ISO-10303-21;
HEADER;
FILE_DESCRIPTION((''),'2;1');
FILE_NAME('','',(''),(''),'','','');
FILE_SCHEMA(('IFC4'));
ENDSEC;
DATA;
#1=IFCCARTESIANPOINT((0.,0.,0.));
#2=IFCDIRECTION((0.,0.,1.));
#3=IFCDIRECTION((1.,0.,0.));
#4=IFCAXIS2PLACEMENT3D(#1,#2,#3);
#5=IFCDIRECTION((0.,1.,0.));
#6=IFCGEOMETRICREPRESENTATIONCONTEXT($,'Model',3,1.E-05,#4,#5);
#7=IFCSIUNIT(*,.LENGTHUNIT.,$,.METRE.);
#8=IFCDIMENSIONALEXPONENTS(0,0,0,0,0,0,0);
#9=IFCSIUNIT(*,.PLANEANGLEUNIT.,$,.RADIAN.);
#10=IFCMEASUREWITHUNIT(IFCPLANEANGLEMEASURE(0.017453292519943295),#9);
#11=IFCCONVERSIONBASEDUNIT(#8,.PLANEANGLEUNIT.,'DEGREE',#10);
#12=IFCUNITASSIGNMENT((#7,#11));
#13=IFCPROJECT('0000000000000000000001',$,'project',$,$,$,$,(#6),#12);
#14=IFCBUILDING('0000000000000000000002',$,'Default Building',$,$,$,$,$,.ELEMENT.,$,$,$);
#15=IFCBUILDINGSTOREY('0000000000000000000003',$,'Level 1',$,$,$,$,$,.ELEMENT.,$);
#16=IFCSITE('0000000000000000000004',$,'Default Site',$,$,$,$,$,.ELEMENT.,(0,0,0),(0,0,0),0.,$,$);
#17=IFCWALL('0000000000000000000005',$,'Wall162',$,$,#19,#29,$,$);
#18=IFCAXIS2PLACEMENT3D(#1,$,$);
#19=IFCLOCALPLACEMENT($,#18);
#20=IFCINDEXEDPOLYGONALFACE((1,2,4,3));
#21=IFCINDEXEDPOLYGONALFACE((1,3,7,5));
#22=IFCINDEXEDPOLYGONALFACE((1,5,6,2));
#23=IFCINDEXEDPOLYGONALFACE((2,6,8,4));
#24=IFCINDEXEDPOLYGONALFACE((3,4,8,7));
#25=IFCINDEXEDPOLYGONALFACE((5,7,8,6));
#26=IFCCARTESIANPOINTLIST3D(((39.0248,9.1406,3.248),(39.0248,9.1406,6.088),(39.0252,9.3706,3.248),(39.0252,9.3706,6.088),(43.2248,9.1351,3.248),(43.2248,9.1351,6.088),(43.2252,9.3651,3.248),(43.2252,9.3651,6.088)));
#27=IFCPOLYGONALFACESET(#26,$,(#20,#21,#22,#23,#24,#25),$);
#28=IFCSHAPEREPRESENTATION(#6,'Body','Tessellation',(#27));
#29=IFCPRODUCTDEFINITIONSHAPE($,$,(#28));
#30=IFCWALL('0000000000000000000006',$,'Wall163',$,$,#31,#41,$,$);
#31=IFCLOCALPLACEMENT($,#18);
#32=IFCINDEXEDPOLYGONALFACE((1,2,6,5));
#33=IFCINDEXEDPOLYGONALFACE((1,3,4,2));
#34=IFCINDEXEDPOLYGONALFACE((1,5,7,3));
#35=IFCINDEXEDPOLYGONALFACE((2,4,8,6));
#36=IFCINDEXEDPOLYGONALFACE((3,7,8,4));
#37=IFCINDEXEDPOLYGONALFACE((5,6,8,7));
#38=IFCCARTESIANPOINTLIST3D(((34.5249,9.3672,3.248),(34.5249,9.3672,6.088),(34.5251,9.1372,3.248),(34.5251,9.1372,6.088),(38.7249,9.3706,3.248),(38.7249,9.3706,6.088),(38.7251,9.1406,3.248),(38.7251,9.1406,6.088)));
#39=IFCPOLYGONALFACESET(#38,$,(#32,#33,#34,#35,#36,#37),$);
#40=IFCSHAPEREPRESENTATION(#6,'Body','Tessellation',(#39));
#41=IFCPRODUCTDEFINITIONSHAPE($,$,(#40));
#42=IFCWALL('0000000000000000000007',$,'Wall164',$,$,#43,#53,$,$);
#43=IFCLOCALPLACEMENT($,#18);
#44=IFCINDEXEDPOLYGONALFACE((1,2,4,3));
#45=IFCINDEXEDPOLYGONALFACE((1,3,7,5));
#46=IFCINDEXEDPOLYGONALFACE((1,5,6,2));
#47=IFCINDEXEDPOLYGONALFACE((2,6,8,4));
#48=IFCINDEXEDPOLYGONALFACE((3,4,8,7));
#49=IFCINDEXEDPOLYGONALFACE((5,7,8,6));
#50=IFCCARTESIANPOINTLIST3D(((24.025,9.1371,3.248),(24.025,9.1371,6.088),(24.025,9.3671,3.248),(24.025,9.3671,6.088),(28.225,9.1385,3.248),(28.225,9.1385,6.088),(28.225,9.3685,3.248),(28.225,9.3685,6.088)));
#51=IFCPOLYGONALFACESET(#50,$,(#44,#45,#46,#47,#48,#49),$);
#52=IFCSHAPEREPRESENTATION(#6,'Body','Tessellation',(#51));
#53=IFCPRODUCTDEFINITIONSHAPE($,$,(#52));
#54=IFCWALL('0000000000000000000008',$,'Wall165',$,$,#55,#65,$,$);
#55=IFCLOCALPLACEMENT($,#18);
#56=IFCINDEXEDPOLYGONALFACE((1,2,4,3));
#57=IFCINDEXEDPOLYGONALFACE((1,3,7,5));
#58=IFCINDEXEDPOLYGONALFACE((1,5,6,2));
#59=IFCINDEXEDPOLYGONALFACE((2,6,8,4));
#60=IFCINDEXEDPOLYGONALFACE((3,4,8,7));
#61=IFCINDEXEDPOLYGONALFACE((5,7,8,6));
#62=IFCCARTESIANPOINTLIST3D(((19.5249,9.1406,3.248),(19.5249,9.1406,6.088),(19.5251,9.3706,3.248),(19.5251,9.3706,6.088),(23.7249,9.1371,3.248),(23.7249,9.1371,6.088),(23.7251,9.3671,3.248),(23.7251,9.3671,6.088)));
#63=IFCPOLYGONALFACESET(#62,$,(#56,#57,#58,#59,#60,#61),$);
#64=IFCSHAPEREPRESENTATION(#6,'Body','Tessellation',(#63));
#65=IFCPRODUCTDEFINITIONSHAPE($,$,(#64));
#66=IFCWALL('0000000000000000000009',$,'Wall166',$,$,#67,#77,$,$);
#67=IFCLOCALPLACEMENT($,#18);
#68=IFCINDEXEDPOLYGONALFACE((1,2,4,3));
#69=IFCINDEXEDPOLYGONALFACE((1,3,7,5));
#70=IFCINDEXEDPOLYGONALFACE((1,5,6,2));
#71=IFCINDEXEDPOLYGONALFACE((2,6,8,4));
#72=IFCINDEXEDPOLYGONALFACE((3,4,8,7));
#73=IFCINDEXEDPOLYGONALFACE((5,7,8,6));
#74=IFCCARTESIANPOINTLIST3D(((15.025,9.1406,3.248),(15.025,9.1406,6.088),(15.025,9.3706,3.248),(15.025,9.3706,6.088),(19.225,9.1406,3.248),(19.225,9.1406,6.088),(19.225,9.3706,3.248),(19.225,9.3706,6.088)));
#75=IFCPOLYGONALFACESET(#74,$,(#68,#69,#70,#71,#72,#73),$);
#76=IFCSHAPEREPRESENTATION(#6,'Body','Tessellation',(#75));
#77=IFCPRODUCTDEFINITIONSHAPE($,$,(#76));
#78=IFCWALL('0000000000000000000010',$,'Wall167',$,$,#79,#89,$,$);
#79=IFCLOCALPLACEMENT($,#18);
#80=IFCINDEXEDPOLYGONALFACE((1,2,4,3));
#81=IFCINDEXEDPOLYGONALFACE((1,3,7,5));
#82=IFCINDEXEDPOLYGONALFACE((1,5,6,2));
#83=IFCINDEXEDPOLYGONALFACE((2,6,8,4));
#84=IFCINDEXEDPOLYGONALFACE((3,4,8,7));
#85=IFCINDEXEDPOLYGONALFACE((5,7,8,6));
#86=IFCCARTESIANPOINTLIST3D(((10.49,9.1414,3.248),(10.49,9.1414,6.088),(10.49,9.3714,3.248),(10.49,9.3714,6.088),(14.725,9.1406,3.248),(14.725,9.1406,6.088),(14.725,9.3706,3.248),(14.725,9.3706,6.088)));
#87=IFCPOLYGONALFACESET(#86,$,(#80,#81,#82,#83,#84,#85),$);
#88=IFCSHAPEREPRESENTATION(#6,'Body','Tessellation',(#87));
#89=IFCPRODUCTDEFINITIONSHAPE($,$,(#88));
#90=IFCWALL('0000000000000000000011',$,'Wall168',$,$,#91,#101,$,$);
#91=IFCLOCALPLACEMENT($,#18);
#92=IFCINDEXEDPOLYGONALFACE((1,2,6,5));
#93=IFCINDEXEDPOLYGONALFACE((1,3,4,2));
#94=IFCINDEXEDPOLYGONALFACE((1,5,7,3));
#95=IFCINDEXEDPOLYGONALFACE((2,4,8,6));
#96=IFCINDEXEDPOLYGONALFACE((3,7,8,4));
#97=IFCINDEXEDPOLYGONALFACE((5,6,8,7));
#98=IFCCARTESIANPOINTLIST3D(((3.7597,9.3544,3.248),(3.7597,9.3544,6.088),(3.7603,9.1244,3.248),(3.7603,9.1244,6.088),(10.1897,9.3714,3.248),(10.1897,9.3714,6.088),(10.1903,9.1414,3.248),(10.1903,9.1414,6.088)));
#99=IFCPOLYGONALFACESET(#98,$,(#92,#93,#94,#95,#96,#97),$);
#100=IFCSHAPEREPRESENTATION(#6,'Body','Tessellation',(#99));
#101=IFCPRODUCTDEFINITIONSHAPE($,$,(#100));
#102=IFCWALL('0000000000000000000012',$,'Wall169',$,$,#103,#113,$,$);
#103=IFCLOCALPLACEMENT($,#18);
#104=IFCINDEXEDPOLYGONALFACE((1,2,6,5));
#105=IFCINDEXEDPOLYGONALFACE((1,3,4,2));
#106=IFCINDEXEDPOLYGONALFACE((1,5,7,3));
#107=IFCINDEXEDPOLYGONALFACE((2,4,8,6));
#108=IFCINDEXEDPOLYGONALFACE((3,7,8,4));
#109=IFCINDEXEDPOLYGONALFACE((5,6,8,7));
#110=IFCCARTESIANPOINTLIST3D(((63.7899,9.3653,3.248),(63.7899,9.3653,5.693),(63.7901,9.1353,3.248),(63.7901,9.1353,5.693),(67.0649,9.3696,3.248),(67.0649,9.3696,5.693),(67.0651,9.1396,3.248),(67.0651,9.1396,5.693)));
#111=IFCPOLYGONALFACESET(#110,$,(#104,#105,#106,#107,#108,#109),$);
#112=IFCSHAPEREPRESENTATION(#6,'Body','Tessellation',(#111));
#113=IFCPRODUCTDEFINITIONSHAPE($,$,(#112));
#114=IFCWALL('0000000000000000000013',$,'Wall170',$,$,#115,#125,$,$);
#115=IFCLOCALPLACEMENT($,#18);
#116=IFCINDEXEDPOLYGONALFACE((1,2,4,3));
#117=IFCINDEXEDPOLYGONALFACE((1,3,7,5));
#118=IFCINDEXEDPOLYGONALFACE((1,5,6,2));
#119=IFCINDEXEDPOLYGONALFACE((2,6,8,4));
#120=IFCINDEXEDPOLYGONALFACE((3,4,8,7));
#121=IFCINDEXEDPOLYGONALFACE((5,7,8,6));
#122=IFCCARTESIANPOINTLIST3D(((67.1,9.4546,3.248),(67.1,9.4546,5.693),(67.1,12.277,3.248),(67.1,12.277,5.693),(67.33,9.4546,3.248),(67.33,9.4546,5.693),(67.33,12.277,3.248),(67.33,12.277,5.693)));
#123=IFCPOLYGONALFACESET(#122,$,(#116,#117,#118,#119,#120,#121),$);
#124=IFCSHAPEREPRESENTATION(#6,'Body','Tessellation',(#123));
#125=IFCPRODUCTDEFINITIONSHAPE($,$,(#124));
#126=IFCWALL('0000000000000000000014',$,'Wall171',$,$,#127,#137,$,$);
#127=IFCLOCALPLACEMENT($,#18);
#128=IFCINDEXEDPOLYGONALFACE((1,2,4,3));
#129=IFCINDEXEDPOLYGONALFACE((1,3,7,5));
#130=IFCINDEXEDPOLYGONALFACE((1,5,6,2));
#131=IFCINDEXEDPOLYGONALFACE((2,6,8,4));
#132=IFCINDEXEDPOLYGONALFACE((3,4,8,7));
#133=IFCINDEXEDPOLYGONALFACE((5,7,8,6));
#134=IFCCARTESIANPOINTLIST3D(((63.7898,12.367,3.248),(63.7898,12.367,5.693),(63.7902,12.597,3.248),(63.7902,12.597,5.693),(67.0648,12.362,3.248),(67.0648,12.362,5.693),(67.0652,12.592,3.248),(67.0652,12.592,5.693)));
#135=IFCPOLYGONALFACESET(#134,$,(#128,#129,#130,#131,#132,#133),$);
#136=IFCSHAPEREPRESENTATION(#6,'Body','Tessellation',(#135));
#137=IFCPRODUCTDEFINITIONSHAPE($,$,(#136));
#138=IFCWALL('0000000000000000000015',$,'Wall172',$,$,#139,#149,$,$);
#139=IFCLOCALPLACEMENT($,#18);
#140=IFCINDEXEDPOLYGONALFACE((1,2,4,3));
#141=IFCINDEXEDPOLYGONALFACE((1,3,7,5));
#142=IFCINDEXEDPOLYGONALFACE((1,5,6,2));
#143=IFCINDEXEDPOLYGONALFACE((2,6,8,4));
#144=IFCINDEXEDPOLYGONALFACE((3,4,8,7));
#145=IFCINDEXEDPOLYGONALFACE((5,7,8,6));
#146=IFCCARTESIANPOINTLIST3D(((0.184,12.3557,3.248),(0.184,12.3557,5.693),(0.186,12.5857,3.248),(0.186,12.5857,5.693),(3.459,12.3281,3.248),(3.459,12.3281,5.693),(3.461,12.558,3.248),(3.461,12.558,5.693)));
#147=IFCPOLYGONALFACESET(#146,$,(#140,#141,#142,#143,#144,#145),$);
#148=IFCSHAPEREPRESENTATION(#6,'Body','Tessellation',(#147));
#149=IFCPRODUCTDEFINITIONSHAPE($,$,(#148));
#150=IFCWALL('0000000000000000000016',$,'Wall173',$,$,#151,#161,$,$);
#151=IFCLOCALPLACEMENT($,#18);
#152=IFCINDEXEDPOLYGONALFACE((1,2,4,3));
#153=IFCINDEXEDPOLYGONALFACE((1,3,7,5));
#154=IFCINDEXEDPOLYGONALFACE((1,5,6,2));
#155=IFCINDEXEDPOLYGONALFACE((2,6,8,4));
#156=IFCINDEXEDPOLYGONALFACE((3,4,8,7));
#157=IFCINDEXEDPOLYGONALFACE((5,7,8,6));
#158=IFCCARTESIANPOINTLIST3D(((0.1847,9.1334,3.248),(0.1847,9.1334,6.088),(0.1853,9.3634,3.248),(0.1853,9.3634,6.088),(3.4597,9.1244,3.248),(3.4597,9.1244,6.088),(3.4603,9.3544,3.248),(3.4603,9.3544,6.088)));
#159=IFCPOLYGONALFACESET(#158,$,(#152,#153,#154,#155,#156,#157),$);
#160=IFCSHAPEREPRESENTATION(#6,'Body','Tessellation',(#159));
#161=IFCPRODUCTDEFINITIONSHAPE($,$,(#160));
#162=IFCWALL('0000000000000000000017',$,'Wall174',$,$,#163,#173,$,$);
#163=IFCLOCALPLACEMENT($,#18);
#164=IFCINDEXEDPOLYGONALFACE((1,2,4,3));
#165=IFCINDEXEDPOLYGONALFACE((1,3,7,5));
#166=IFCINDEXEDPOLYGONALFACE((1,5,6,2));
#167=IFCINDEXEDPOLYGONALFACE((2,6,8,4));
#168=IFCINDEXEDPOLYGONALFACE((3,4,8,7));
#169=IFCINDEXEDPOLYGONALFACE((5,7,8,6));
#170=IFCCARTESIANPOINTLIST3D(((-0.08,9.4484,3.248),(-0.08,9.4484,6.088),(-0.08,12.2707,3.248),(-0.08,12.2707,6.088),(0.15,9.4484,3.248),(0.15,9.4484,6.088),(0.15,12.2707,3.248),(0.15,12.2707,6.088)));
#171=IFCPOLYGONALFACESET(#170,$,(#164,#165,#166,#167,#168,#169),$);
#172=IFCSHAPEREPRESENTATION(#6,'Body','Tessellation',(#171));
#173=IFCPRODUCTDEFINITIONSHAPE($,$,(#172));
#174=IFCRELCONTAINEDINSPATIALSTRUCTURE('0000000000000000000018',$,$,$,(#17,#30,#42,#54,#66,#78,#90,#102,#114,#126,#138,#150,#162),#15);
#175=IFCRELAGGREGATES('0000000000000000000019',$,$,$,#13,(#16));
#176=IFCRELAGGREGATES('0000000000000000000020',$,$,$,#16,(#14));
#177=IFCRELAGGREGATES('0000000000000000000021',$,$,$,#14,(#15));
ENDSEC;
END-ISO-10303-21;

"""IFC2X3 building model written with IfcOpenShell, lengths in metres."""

from ifc_helpers import new_model, entity, si_unit, converted_unit, direction, frame, frame_2d, origin_with_axes, place, context, project, spatial, rectangle, extrude, element, save


model = new_model("IFC2X3")

# Units and contexts
model_context = context("Model", 3, precision=1e-05, world=origin_with_axes(), true_north=direction((0.0, 1.0, 0.0)))
ifc_project = project(units=[si_unit("LENGTHUNIT", "METRE"), converted_unit("PLANEANGLEUNIT", "DEGREE", entity("IfcPlaneAngleMeasure", 0.017453292519943295), si_unit("PLANEANGLEUNIT", "RADIAN"), dimensions=[0, 0, 0, 0, 0, 0, 0])], contexts=[model_context])

# Site, building, storey
site = spatial("IfcSite", under=ifc_project, Name="Default Site", CompositionType="ELEMENT", RefLatitude=(0, 0, 0), RefLongitude=(0, 0, 0), RefElevation=0.0)
building = spatial("IfcBuilding", under=site, Name="Default Building", CompositionType="ELEMENT")
storey = spatial("IfcBuildingStorey", under=building, Name="Level 1", CompositionType="ELEMENT")

# Walls
placement = place(None, origin_with_axes())
element("IfcWall", 1, at=placement, inside=storey, Name="Wall162", context=model_context, shape_type="SweptSolid", body=[
    extrude(rectangle(XDim=4.2, YDim=0.23, at=frame_2d((0.0, 0.0), x_axis=(-0.999999, 0.001314, 0.0))), frame((41.125, 9.2528, 3.248), z_axis=(0.0, 0.0, 1.0), x_axis=(1.0, 0.0, 0.0)), (0.0, 0.0, 1.0), 2.84),
])
element("IfcWall", 2, at=placement, inside=storey, Name="Wall163", context=model_context, shape_type="SweptSolid", body=[
    extrude(rectangle(XDim=4.2, YDim=0.23, at=frame_2d((0.0, 0.0), x_axis=(1.0, 0.000801, 0.0))), frame((36.625, 9.2539, 3.248), z_axis=(0.0, 0.0, 1.0), x_axis=(1.0, 0.0, 0.0)), (0.0, 0.0, 1.0), 2.84),
])
element("IfcWall", 3, at=placement, inside=storey, Name="Wall164", context=model_context, shape_type="SweptSolid", body=[
    extrude(rectangle(XDim=4.2, YDim=0.23, at=frame_2d((0.0, 0.0), x_axis=(-1.0, -0.000329, 0.0))), frame((26.125, 9.2528, 3.248), z_axis=(0.0, 0.0, 1.0), x_axis=(1.0, 0.0, 0.0)), (0.0, 0.0, 1.0), 2.84),
])
element("IfcWall", 4, at=placement, inside=storey, Name="Wall165", context=model_context, shape_type="SweptSolid", body=[
    extrude(rectangle(XDim=4.2, YDim=0.23, at=frame_2d((0.0, 0.0), x_axis=(-1.0, 0.000835, 0.0))), frame((21.625, 9.2539, 3.248), z_axis=(0.0, 0.0, 1.0), x_axis=(1.0, 0.0, 0.0)), (0.0, 0.0, 1.0), 2.84),
])
element("IfcWall", 5, at=placement, inside=storey, Name="Wall166", context=model_context, shape_type="SweptSolid", body=[
    extrude(rectangle(XDim=4.2, YDim=0.23, at=frame_2d((0.0, 0.0), x_axis=(-1.0, -0.000014, 0.0))), frame((17.125, 9.2556, 3.248), z_axis=(0.0, 0.0, 1.0), x_axis=(1.0, 0.0, 0.0)), (0.0, 0.0, 1.0), 2.84),
])
element("IfcWall", 6, at=placement, inside=storey, Name="Wall167", context=model_context, shape_type="SweptSolid", body=[
    extrude(rectangle(XDim=4.235, YDim=0.23, at=frame_2d((0.0, 0.0), x_axis=(1.0, -0.000195, 0.0))), frame((12.6075, 9.256, 3.248), z_axis=(0.0, 0.0, 1.0), x_axis=(1.0, 0.0, 0.0)), (0.0, 0.0, 1.0), 2.84),
])
element("IfcWall", 7, at=placement, inside=storey, Name="Wall168", context=model_context, shape_type="SweptSolid", body=[
    extrude(rectangle(XDim=6.43, YDim=0.23, at=frame_2d((0.0, 0.0), x_axis=(-0.999997, -0.002639, 0.0))), frame((6.975, 9.2479, 3.248), z_axis=(0.0, 0.0, 1.0), x_axis=(1.0, 0.0, 0.0)), (0.0, 0.0, 1.0), 2.84),
])
element("IfcWall", 8, at=placement, inside=storey, Name="Wall169", context=model_context, shape_type="SweptSolid", body=[
    extrude(rectangle(XDim=3.275, YDim=0.23, at=frame_2d((0.0, 0.0), x_axis=(0.999999, 0.001297, 0.0))), frame((65.4275, 9.2525, 3.248), z_axis=(0.0, 0.0, 1.0), x_axis=(1.0, 0.0, 0.0)), (0.0, 0.0, 1.0), 2.445),
])
element("IfcWall", 9, at=placement, inside=storey, Name="Wall170", context=model_context, shape_type="SweptSolid", body=[
    extrude(rectangle(XDim=2.8224, YDim=0.23, at=frame_2d((0.0, 0.0), x_axis=(0.0, -1.0, 0.0))), frame((67.215, 10.8658, 3.248), z_axis=(0.0, 0.0, 1.0), x_axis=(1.0, 0.0, 0.0)), (0.0, 0.0, 1.0), 2.445),
])
element("IfcWall", 10, at=placement, inside=storey, Name="Wall171", context=model_context, shape_type="SweptSolid", body=[
    extrude(rectangle(XDim=3.275, YDim=0.23, at=frame_2d((0.0, 0.0), x_axis=(0.999999, -0.001506, 0.0))), frame((65.4275, 12.4795, 3.248), z_axis=(0.0, 0.0, 1.0), x_axis=(1.0, 0.0, 0.0)), (0.0, 0.0, 1.0), 2.445),
])
element("IfcWall", 11, at=placement, inside=storey, Name="Wall172", context=model_context, shape_type="SweptSolid", body=[
    extrude(rectangle(XDim=3.2751, YDim=0.23, at=frame_2d((0.0, 0.0), x_axis=(-0.999964, 0.008443, 0.0))), frame((1.8225, 12.4569, 3.248), z_axis=(0.0, 0.0, 1.0), x_axis=(1.0, 0.0, 0.0)), (0.0, 0.0, 1.0), 2.445),
])
element("IfcWall", 12, at=placement, inside=storey, Name="Wall173", context=model_context, shape_type="SweptSolid", body=[
    extrude(rectangle(XDim=3.275, YDim=0.23, at=frame_2d((0.0, 0.0), x_axis=(0.999996, -0.002728, 0.0))), frame((1.8225, 9.2439, 3.248), z_axis=(0.0, 0.0, 1.0), x_axis=(1.0, 0.0, 0.0)), (0.0, 0.0, 1.0), 2.84),
])
element("IfcWall", 13, at=placement, inside=storey, Name="Wall174", context=model_context, shape_type="SweptSolid", body=[
    extrude(rectangle(XDim=2.8223, YDim=0.23, at=frame_2d((0.0, 0.0), x_axis=(0.0, 1.0, 0.0))), frame((0.035, 10.8595, 3.248), z_axis=(0.0, 0.0, 1.0), x_axis=(1.0, 0.0, 0.0)), (0.0, 0.0, 1.0), 2.84),
])

save(model, "model.ifc")
